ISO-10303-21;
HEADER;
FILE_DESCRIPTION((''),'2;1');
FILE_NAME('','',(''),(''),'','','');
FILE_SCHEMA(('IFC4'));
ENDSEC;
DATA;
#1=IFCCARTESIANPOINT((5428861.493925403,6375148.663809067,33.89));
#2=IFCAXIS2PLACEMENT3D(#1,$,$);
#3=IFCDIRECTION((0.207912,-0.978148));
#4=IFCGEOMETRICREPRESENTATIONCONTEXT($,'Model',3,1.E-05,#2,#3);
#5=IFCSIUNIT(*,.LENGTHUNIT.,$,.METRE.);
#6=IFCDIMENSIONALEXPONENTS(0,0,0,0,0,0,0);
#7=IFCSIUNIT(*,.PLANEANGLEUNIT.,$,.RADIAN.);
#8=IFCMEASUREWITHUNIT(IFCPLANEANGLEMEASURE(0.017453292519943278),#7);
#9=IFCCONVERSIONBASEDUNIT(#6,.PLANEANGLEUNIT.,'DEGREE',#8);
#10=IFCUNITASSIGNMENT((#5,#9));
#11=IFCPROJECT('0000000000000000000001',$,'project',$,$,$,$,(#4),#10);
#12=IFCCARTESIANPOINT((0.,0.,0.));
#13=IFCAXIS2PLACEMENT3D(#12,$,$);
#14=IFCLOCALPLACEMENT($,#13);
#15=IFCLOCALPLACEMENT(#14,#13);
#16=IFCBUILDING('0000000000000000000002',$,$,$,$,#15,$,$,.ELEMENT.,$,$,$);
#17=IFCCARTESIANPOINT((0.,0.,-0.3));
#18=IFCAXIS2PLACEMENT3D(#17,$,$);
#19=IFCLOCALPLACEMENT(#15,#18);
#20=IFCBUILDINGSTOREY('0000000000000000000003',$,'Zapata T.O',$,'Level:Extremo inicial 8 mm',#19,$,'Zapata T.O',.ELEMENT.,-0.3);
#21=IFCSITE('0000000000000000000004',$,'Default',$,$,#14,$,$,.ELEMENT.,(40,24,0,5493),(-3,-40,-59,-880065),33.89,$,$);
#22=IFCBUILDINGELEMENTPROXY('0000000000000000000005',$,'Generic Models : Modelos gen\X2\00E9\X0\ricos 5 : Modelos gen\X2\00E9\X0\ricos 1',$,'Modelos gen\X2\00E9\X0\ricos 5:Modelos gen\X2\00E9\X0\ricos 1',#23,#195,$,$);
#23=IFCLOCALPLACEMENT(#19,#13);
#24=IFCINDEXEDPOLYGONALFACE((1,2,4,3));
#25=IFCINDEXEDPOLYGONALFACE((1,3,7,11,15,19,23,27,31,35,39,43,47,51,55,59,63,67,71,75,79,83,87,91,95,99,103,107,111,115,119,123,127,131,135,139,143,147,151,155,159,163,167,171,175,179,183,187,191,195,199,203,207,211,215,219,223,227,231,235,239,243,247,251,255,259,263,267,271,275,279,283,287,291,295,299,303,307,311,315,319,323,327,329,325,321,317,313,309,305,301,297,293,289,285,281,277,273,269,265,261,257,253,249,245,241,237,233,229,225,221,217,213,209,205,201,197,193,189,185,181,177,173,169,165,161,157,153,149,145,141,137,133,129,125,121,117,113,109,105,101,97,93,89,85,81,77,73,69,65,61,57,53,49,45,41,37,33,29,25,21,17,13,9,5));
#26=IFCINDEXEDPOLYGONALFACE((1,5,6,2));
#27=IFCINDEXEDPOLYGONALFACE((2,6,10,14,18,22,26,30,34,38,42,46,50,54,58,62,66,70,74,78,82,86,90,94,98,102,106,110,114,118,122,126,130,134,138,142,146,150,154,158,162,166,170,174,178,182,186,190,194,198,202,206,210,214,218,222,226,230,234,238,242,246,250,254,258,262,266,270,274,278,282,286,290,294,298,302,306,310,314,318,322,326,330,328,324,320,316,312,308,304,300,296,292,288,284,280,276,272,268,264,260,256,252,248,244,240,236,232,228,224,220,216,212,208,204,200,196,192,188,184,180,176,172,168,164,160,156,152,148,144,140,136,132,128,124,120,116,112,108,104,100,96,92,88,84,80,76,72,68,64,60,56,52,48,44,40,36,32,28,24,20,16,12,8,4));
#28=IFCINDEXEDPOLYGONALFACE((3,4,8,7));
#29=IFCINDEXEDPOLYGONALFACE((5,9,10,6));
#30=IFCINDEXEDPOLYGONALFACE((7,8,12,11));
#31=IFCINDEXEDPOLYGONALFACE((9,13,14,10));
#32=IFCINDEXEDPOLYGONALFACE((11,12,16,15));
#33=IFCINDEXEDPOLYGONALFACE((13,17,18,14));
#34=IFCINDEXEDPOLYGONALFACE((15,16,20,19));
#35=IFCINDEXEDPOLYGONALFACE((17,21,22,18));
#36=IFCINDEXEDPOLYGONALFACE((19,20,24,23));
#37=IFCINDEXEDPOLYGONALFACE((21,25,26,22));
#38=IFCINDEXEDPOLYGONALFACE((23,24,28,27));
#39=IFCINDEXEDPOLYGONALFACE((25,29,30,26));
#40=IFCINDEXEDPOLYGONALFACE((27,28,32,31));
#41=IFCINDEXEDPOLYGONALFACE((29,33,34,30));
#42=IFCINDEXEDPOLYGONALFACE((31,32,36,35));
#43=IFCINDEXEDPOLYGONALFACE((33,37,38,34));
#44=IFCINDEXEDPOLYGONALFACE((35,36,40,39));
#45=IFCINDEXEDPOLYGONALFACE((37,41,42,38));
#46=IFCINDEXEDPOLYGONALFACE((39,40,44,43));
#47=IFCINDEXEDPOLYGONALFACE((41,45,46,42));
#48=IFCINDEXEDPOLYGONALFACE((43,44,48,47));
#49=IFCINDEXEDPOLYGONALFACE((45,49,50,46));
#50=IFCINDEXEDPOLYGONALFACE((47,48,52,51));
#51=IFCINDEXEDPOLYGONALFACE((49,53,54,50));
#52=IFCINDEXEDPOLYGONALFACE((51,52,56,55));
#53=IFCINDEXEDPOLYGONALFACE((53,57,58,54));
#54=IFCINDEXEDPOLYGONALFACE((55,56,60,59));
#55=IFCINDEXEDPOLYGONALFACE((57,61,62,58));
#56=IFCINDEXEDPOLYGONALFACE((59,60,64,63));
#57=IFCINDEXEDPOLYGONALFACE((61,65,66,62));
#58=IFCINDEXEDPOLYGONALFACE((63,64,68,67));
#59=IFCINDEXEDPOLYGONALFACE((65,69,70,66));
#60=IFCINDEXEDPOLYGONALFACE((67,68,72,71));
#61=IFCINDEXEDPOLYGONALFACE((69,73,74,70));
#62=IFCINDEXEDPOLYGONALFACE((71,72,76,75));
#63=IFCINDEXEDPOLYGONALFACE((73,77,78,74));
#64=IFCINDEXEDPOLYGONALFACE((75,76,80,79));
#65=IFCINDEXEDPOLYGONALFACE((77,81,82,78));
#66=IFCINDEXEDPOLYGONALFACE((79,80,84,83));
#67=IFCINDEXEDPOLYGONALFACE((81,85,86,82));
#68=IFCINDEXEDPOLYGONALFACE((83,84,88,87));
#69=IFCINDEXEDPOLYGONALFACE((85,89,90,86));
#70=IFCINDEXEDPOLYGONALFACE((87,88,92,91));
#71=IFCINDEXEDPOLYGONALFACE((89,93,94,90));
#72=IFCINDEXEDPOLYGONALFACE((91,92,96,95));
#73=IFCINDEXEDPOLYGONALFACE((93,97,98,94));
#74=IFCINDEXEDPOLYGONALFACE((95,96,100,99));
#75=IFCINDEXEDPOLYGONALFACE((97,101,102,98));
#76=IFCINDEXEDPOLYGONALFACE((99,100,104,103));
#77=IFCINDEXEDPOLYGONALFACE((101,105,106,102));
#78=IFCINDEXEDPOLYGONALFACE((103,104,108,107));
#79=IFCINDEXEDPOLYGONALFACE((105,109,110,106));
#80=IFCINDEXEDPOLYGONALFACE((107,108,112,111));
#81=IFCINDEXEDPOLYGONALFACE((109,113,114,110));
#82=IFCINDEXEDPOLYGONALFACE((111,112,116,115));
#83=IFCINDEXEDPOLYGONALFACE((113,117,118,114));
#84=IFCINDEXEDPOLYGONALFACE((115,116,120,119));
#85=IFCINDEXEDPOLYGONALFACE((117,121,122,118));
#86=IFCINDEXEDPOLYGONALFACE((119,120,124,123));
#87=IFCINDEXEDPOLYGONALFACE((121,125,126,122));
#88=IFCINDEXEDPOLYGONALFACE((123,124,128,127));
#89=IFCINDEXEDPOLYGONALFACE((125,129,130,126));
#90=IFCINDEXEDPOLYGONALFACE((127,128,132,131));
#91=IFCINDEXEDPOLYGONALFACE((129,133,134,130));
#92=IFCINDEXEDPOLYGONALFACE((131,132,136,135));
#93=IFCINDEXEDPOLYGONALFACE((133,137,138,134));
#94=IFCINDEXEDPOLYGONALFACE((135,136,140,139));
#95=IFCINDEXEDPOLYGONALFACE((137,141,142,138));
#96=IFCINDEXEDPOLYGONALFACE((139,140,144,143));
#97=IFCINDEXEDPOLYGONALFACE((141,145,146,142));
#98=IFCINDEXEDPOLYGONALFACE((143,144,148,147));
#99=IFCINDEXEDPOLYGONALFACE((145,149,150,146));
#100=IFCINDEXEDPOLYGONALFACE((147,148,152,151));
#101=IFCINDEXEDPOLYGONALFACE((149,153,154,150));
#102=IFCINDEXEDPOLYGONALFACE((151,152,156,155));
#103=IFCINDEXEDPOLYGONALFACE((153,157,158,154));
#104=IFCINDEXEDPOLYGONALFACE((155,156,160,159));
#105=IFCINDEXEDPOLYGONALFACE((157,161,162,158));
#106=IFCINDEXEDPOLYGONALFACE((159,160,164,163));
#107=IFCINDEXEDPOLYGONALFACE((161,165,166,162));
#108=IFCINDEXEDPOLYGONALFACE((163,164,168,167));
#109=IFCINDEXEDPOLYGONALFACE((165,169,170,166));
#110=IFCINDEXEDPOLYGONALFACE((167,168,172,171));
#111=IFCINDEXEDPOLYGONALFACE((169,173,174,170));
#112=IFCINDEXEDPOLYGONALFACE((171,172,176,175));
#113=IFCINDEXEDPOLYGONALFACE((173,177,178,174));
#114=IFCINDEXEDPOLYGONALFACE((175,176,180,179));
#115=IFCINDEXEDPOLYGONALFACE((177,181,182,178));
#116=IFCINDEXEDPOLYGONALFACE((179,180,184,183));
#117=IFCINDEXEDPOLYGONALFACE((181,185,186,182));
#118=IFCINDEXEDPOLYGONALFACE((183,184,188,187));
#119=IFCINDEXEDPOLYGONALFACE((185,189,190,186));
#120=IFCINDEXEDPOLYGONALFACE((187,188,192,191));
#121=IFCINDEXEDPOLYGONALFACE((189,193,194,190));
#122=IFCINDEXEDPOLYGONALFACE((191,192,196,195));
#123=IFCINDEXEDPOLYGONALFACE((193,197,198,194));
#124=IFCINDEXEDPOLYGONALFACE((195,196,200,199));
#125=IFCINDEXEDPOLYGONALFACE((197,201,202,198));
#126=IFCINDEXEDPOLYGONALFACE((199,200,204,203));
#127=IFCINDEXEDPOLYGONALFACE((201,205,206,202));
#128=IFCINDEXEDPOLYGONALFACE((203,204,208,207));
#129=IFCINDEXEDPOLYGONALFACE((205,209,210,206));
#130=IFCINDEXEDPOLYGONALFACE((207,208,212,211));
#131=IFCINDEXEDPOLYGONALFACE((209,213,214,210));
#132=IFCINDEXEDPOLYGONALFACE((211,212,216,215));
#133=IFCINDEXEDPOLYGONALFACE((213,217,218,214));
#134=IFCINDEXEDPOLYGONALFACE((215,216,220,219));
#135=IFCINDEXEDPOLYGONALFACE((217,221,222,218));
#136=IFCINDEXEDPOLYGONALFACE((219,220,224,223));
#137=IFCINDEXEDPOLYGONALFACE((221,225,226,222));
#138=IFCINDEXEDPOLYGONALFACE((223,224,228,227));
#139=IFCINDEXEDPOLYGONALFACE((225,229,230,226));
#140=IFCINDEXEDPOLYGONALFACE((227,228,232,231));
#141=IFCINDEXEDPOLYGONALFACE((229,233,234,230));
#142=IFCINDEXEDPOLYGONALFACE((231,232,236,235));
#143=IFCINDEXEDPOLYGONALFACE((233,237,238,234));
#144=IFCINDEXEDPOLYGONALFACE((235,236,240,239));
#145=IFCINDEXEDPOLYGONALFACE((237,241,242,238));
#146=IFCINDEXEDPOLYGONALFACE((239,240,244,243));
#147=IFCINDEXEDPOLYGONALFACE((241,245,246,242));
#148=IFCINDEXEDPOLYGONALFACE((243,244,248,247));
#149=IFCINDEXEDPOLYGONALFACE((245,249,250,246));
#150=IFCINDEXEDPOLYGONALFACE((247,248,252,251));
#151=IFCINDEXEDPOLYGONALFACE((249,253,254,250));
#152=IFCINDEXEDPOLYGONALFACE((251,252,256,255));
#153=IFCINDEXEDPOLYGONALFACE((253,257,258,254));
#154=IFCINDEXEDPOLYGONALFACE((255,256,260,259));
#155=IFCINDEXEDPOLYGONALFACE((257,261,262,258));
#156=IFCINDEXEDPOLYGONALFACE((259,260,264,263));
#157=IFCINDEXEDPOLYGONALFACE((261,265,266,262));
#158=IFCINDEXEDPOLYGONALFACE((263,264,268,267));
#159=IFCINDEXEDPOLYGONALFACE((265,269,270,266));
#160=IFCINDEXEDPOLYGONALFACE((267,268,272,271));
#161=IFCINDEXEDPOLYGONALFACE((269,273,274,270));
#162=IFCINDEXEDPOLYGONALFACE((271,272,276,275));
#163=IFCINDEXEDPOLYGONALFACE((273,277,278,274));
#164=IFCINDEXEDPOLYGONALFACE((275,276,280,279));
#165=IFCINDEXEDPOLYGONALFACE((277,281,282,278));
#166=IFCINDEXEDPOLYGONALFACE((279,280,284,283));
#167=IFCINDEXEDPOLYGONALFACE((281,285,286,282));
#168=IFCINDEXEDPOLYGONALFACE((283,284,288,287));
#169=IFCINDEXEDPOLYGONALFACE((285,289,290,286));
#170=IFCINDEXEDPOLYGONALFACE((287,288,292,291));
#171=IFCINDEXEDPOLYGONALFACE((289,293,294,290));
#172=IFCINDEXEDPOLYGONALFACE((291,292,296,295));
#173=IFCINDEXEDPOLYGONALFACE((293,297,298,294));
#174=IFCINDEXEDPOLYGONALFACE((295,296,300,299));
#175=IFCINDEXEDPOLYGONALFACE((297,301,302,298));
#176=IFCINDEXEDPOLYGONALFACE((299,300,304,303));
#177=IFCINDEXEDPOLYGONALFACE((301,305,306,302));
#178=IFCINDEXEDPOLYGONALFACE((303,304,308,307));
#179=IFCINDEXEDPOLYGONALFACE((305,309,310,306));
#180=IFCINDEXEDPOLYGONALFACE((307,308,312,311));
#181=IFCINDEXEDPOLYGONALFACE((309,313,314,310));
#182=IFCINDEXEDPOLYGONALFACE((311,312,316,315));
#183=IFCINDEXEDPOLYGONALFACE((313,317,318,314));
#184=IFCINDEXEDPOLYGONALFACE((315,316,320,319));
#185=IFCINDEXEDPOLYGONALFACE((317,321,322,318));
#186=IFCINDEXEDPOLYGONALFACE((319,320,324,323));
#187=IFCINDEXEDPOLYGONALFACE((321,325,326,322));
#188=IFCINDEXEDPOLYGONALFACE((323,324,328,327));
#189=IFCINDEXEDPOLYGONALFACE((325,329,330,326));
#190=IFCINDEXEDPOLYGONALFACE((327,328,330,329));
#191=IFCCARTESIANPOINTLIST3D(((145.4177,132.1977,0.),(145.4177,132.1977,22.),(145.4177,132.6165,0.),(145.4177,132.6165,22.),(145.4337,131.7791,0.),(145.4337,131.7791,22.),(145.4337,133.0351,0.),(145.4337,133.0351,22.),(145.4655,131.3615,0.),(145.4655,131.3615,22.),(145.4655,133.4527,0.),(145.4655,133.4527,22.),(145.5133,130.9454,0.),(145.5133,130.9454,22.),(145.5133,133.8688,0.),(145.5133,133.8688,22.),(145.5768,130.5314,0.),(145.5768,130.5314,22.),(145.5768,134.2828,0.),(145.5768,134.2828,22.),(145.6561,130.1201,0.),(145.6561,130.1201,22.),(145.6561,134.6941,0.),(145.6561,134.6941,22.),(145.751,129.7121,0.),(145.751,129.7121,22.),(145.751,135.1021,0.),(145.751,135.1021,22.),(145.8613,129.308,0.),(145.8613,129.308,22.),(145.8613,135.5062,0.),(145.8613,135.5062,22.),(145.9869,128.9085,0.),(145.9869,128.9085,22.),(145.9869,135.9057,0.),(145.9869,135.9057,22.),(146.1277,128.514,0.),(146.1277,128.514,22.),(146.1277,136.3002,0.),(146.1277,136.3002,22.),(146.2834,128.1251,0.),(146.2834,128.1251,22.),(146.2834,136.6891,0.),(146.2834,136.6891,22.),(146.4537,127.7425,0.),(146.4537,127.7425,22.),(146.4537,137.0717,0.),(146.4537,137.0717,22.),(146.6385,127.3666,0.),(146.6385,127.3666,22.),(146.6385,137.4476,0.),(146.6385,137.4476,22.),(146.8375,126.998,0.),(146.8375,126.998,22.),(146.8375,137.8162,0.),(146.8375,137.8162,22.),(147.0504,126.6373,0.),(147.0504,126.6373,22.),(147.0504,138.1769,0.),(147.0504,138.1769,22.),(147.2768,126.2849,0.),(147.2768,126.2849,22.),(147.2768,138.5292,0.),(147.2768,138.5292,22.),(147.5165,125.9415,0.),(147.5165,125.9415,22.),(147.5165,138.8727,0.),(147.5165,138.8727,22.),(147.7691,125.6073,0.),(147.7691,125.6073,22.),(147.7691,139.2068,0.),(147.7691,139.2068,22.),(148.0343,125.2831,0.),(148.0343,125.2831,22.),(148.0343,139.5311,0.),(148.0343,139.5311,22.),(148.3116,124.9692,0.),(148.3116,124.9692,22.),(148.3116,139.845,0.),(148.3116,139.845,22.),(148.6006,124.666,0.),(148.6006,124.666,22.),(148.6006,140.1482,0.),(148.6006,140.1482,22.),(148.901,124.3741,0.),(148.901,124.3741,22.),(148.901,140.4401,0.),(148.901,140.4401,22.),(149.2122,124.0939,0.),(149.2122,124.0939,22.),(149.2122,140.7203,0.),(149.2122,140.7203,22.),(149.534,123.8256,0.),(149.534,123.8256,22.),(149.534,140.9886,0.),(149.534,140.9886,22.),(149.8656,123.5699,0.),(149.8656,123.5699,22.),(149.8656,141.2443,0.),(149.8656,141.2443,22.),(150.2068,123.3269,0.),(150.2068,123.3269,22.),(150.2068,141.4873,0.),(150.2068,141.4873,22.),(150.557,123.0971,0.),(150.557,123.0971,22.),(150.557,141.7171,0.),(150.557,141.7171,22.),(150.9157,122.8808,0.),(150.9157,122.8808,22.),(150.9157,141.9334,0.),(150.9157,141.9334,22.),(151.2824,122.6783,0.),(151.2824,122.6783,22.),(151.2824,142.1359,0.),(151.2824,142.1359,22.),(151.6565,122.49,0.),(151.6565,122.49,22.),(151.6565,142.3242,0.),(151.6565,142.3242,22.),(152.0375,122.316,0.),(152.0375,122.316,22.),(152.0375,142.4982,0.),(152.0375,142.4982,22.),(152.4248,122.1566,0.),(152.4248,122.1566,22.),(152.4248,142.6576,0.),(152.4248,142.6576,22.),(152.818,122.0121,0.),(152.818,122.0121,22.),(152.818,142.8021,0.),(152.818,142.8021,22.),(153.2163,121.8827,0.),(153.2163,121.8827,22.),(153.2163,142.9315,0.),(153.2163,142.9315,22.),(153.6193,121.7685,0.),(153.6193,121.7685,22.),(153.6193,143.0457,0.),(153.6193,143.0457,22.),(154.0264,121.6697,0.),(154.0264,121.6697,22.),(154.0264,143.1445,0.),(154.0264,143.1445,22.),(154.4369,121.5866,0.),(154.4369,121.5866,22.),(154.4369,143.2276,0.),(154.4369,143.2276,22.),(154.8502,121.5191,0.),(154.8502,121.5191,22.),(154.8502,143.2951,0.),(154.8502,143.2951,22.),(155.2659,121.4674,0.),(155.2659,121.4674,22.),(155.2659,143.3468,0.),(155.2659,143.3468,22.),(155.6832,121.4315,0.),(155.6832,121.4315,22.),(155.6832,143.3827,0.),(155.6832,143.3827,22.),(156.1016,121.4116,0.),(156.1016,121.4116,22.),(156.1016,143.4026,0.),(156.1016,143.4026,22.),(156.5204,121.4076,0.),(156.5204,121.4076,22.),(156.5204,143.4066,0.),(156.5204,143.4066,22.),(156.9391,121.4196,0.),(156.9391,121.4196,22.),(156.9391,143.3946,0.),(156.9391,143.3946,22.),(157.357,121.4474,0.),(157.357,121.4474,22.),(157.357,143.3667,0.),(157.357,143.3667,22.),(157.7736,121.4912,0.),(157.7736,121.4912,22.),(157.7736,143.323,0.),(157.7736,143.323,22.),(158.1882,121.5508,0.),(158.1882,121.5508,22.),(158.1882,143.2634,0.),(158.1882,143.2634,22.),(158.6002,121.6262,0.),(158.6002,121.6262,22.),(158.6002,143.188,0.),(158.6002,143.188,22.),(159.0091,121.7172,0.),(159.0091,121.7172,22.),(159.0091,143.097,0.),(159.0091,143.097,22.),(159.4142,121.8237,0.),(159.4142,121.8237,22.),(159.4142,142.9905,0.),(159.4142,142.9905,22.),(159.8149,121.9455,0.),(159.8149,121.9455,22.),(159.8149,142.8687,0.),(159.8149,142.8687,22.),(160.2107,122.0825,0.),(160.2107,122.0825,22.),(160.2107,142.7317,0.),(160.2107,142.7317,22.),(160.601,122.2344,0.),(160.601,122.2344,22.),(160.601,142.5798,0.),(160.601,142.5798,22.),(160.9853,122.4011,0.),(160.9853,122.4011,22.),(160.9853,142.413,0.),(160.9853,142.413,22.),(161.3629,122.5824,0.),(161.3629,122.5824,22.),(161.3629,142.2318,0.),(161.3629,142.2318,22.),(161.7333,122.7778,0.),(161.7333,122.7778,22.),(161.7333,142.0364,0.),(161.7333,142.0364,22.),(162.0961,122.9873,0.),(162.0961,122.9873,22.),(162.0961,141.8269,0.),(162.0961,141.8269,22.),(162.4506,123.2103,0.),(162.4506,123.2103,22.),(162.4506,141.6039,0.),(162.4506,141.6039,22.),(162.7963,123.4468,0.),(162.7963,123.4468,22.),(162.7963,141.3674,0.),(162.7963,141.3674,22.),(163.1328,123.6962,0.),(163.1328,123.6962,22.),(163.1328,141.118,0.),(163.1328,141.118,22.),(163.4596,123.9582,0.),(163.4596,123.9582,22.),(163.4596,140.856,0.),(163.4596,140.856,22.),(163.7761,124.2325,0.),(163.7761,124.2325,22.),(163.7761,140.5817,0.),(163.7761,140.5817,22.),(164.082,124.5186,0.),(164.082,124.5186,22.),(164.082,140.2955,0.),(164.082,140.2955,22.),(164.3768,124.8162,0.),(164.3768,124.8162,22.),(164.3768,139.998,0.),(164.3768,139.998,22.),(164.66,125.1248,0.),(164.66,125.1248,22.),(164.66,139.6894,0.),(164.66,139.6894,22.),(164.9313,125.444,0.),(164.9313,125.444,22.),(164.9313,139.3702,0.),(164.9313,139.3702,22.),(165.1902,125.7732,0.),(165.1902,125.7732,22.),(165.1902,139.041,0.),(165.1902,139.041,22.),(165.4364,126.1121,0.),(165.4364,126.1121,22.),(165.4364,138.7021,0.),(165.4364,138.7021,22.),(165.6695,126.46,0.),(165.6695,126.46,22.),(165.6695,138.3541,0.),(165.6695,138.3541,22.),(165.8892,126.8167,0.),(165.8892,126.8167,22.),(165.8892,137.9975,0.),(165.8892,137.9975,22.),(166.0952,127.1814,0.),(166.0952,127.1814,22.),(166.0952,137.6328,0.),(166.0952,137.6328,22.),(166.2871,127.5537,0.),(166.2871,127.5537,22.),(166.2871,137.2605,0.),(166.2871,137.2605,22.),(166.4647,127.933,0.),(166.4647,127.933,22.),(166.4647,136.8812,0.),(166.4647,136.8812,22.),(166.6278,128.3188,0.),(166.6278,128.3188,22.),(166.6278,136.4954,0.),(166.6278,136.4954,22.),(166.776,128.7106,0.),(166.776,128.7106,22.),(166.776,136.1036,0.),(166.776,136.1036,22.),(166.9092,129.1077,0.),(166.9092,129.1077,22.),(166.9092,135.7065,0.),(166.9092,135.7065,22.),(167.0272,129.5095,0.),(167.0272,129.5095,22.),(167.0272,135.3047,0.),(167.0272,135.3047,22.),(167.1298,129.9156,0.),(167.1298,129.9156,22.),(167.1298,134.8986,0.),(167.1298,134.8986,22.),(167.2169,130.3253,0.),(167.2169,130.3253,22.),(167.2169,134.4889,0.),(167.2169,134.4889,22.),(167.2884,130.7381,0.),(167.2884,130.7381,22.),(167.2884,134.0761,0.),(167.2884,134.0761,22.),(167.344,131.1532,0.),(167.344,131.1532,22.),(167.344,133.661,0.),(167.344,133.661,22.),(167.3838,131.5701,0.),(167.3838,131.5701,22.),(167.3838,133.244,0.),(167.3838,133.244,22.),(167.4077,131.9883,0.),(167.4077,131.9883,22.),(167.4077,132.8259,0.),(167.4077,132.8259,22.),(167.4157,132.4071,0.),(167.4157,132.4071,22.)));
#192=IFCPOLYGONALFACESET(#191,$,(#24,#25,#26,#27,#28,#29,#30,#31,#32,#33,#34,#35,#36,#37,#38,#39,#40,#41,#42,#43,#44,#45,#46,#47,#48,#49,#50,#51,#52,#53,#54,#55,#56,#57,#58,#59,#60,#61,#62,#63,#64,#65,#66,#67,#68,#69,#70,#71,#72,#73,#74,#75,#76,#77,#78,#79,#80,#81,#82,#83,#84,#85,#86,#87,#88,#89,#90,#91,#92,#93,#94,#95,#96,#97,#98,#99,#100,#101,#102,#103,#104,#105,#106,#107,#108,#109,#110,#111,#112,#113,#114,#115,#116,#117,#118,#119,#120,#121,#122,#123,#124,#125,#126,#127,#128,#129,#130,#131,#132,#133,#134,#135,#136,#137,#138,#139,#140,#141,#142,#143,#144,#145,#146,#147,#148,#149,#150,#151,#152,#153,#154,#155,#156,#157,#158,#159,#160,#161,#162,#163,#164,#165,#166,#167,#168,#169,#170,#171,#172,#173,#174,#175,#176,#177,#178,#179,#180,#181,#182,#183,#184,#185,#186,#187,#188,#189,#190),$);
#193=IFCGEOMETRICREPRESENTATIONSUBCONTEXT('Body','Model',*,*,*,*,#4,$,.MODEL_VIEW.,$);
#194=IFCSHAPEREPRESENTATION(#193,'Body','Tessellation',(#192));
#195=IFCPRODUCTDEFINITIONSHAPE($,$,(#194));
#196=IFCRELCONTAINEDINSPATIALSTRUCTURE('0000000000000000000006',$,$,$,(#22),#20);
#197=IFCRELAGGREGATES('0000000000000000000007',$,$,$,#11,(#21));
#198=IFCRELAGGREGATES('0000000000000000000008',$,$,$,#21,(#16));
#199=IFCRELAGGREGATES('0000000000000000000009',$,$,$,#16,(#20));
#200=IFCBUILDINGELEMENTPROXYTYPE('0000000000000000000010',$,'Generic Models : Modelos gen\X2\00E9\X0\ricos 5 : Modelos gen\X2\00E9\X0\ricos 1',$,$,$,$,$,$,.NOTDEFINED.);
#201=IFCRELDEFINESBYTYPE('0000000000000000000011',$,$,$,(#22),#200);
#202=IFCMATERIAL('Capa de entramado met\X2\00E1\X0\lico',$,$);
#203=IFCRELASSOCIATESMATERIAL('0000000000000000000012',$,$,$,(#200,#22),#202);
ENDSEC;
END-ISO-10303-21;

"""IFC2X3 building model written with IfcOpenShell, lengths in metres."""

from ifc_helpers import new_model, entity, si_unit, converted_unit, direction, frame, frame_2d, origin, place, context, subcontext, project, spatial, circle, extrude, source, transform, mapped, material, type_object, type_shapes, element, save


model = new_model("IFC2X3")

# Units and contexts
model_context = context("Model", 3, precision=1e-05, world=frame((5428861.493925403, 6375148.663809067, 33.89)), true_north=direction((0.207912, -0.978148)))
body_context = subcontext(model_context, "Body", "Model", "MODEL_VIEW")
ifc_project = project(units=[si_unit("LENGTHUNIT", "METRE"), converted_unit("PLANEANGLEUNIT", "DEGREE", entity("IfcPlaneAngleMeasure", 0.017453292519943278), si_unit("PLANEANGLEUNIT", "RADIAN"), dimensions=[0, 0, 0, 0, 0, 0, 0])], contexts=[model_context])

# Site, building, storey
site_placement = place(None, origin())
site = spatial("IfcSite", under=ifc_project, at=site_placement, Name="Default", CompositionType="ELEMENT", RefLatitude=(40, 24, 0, 5493), RefLongitude=(-3, -40, -59, -880065), RefElevation=33.89)
building_placement = place(site_placement, origin())
building = spatial("IfcBuilding", under=site, at=building_placement, CompositionType="ELEMENT")
storey_placement = place(building_placement, frame((0.0, 0.0, -0.3)))
storey = spatial("IfcBuildingStorey", under=building, at=storey_placement, Name="Zapata T.O", ObjectType="Level:Extremo inicial 8 mm", LongName="Zapata T.O", CompositionType="ELEMENT", Elevation=-0.3)

# Building element proxy
ifc_material = material(Name="Capa de entramado metálico")
building_element_proxy_type_1 = type_object("IfcBuildingElementProxyType", Name="Generic Models : Modelos genéricos 5 : Modelos genéricos 1", PredefinedType="NOTDEFINED", material=ifc_material)
shared_shape_1 = source(origin(), body_context, "Body", "SweptSolid", [
    extrude(circle(Radius=11.0, at=frame_2d((0.0, 0.0), x_axis=(1.0, 0.0))), frame((156.4157, 132.4071, -0.3)), (0.0, 0.0, 1.0), 22.0),
])
type_shapes(building_element_proxy_type_1, [shared_shape_1])
proxy_1_placement = place(storey_placement, frame((0.0, 0.0, 0.3)))
element("IfcBuildingElementProxy", 1, at=proxy_1_placement, inside=storey, type_object=building_element_proxy_type_1, material=ifc_material, Name="Generic Models : Modelos genéricos 5 : Modelos genéricos 1", ObjectType="Modelos genéricos 5:Modelos genéricos 1", context=body_context, shape_type="MappedRepresentation", body=[
    mapped(shared_shape_1, transform((0.0, 0.0, 0.0), scale=1.0)),
])

save(model, "model.ifc")
